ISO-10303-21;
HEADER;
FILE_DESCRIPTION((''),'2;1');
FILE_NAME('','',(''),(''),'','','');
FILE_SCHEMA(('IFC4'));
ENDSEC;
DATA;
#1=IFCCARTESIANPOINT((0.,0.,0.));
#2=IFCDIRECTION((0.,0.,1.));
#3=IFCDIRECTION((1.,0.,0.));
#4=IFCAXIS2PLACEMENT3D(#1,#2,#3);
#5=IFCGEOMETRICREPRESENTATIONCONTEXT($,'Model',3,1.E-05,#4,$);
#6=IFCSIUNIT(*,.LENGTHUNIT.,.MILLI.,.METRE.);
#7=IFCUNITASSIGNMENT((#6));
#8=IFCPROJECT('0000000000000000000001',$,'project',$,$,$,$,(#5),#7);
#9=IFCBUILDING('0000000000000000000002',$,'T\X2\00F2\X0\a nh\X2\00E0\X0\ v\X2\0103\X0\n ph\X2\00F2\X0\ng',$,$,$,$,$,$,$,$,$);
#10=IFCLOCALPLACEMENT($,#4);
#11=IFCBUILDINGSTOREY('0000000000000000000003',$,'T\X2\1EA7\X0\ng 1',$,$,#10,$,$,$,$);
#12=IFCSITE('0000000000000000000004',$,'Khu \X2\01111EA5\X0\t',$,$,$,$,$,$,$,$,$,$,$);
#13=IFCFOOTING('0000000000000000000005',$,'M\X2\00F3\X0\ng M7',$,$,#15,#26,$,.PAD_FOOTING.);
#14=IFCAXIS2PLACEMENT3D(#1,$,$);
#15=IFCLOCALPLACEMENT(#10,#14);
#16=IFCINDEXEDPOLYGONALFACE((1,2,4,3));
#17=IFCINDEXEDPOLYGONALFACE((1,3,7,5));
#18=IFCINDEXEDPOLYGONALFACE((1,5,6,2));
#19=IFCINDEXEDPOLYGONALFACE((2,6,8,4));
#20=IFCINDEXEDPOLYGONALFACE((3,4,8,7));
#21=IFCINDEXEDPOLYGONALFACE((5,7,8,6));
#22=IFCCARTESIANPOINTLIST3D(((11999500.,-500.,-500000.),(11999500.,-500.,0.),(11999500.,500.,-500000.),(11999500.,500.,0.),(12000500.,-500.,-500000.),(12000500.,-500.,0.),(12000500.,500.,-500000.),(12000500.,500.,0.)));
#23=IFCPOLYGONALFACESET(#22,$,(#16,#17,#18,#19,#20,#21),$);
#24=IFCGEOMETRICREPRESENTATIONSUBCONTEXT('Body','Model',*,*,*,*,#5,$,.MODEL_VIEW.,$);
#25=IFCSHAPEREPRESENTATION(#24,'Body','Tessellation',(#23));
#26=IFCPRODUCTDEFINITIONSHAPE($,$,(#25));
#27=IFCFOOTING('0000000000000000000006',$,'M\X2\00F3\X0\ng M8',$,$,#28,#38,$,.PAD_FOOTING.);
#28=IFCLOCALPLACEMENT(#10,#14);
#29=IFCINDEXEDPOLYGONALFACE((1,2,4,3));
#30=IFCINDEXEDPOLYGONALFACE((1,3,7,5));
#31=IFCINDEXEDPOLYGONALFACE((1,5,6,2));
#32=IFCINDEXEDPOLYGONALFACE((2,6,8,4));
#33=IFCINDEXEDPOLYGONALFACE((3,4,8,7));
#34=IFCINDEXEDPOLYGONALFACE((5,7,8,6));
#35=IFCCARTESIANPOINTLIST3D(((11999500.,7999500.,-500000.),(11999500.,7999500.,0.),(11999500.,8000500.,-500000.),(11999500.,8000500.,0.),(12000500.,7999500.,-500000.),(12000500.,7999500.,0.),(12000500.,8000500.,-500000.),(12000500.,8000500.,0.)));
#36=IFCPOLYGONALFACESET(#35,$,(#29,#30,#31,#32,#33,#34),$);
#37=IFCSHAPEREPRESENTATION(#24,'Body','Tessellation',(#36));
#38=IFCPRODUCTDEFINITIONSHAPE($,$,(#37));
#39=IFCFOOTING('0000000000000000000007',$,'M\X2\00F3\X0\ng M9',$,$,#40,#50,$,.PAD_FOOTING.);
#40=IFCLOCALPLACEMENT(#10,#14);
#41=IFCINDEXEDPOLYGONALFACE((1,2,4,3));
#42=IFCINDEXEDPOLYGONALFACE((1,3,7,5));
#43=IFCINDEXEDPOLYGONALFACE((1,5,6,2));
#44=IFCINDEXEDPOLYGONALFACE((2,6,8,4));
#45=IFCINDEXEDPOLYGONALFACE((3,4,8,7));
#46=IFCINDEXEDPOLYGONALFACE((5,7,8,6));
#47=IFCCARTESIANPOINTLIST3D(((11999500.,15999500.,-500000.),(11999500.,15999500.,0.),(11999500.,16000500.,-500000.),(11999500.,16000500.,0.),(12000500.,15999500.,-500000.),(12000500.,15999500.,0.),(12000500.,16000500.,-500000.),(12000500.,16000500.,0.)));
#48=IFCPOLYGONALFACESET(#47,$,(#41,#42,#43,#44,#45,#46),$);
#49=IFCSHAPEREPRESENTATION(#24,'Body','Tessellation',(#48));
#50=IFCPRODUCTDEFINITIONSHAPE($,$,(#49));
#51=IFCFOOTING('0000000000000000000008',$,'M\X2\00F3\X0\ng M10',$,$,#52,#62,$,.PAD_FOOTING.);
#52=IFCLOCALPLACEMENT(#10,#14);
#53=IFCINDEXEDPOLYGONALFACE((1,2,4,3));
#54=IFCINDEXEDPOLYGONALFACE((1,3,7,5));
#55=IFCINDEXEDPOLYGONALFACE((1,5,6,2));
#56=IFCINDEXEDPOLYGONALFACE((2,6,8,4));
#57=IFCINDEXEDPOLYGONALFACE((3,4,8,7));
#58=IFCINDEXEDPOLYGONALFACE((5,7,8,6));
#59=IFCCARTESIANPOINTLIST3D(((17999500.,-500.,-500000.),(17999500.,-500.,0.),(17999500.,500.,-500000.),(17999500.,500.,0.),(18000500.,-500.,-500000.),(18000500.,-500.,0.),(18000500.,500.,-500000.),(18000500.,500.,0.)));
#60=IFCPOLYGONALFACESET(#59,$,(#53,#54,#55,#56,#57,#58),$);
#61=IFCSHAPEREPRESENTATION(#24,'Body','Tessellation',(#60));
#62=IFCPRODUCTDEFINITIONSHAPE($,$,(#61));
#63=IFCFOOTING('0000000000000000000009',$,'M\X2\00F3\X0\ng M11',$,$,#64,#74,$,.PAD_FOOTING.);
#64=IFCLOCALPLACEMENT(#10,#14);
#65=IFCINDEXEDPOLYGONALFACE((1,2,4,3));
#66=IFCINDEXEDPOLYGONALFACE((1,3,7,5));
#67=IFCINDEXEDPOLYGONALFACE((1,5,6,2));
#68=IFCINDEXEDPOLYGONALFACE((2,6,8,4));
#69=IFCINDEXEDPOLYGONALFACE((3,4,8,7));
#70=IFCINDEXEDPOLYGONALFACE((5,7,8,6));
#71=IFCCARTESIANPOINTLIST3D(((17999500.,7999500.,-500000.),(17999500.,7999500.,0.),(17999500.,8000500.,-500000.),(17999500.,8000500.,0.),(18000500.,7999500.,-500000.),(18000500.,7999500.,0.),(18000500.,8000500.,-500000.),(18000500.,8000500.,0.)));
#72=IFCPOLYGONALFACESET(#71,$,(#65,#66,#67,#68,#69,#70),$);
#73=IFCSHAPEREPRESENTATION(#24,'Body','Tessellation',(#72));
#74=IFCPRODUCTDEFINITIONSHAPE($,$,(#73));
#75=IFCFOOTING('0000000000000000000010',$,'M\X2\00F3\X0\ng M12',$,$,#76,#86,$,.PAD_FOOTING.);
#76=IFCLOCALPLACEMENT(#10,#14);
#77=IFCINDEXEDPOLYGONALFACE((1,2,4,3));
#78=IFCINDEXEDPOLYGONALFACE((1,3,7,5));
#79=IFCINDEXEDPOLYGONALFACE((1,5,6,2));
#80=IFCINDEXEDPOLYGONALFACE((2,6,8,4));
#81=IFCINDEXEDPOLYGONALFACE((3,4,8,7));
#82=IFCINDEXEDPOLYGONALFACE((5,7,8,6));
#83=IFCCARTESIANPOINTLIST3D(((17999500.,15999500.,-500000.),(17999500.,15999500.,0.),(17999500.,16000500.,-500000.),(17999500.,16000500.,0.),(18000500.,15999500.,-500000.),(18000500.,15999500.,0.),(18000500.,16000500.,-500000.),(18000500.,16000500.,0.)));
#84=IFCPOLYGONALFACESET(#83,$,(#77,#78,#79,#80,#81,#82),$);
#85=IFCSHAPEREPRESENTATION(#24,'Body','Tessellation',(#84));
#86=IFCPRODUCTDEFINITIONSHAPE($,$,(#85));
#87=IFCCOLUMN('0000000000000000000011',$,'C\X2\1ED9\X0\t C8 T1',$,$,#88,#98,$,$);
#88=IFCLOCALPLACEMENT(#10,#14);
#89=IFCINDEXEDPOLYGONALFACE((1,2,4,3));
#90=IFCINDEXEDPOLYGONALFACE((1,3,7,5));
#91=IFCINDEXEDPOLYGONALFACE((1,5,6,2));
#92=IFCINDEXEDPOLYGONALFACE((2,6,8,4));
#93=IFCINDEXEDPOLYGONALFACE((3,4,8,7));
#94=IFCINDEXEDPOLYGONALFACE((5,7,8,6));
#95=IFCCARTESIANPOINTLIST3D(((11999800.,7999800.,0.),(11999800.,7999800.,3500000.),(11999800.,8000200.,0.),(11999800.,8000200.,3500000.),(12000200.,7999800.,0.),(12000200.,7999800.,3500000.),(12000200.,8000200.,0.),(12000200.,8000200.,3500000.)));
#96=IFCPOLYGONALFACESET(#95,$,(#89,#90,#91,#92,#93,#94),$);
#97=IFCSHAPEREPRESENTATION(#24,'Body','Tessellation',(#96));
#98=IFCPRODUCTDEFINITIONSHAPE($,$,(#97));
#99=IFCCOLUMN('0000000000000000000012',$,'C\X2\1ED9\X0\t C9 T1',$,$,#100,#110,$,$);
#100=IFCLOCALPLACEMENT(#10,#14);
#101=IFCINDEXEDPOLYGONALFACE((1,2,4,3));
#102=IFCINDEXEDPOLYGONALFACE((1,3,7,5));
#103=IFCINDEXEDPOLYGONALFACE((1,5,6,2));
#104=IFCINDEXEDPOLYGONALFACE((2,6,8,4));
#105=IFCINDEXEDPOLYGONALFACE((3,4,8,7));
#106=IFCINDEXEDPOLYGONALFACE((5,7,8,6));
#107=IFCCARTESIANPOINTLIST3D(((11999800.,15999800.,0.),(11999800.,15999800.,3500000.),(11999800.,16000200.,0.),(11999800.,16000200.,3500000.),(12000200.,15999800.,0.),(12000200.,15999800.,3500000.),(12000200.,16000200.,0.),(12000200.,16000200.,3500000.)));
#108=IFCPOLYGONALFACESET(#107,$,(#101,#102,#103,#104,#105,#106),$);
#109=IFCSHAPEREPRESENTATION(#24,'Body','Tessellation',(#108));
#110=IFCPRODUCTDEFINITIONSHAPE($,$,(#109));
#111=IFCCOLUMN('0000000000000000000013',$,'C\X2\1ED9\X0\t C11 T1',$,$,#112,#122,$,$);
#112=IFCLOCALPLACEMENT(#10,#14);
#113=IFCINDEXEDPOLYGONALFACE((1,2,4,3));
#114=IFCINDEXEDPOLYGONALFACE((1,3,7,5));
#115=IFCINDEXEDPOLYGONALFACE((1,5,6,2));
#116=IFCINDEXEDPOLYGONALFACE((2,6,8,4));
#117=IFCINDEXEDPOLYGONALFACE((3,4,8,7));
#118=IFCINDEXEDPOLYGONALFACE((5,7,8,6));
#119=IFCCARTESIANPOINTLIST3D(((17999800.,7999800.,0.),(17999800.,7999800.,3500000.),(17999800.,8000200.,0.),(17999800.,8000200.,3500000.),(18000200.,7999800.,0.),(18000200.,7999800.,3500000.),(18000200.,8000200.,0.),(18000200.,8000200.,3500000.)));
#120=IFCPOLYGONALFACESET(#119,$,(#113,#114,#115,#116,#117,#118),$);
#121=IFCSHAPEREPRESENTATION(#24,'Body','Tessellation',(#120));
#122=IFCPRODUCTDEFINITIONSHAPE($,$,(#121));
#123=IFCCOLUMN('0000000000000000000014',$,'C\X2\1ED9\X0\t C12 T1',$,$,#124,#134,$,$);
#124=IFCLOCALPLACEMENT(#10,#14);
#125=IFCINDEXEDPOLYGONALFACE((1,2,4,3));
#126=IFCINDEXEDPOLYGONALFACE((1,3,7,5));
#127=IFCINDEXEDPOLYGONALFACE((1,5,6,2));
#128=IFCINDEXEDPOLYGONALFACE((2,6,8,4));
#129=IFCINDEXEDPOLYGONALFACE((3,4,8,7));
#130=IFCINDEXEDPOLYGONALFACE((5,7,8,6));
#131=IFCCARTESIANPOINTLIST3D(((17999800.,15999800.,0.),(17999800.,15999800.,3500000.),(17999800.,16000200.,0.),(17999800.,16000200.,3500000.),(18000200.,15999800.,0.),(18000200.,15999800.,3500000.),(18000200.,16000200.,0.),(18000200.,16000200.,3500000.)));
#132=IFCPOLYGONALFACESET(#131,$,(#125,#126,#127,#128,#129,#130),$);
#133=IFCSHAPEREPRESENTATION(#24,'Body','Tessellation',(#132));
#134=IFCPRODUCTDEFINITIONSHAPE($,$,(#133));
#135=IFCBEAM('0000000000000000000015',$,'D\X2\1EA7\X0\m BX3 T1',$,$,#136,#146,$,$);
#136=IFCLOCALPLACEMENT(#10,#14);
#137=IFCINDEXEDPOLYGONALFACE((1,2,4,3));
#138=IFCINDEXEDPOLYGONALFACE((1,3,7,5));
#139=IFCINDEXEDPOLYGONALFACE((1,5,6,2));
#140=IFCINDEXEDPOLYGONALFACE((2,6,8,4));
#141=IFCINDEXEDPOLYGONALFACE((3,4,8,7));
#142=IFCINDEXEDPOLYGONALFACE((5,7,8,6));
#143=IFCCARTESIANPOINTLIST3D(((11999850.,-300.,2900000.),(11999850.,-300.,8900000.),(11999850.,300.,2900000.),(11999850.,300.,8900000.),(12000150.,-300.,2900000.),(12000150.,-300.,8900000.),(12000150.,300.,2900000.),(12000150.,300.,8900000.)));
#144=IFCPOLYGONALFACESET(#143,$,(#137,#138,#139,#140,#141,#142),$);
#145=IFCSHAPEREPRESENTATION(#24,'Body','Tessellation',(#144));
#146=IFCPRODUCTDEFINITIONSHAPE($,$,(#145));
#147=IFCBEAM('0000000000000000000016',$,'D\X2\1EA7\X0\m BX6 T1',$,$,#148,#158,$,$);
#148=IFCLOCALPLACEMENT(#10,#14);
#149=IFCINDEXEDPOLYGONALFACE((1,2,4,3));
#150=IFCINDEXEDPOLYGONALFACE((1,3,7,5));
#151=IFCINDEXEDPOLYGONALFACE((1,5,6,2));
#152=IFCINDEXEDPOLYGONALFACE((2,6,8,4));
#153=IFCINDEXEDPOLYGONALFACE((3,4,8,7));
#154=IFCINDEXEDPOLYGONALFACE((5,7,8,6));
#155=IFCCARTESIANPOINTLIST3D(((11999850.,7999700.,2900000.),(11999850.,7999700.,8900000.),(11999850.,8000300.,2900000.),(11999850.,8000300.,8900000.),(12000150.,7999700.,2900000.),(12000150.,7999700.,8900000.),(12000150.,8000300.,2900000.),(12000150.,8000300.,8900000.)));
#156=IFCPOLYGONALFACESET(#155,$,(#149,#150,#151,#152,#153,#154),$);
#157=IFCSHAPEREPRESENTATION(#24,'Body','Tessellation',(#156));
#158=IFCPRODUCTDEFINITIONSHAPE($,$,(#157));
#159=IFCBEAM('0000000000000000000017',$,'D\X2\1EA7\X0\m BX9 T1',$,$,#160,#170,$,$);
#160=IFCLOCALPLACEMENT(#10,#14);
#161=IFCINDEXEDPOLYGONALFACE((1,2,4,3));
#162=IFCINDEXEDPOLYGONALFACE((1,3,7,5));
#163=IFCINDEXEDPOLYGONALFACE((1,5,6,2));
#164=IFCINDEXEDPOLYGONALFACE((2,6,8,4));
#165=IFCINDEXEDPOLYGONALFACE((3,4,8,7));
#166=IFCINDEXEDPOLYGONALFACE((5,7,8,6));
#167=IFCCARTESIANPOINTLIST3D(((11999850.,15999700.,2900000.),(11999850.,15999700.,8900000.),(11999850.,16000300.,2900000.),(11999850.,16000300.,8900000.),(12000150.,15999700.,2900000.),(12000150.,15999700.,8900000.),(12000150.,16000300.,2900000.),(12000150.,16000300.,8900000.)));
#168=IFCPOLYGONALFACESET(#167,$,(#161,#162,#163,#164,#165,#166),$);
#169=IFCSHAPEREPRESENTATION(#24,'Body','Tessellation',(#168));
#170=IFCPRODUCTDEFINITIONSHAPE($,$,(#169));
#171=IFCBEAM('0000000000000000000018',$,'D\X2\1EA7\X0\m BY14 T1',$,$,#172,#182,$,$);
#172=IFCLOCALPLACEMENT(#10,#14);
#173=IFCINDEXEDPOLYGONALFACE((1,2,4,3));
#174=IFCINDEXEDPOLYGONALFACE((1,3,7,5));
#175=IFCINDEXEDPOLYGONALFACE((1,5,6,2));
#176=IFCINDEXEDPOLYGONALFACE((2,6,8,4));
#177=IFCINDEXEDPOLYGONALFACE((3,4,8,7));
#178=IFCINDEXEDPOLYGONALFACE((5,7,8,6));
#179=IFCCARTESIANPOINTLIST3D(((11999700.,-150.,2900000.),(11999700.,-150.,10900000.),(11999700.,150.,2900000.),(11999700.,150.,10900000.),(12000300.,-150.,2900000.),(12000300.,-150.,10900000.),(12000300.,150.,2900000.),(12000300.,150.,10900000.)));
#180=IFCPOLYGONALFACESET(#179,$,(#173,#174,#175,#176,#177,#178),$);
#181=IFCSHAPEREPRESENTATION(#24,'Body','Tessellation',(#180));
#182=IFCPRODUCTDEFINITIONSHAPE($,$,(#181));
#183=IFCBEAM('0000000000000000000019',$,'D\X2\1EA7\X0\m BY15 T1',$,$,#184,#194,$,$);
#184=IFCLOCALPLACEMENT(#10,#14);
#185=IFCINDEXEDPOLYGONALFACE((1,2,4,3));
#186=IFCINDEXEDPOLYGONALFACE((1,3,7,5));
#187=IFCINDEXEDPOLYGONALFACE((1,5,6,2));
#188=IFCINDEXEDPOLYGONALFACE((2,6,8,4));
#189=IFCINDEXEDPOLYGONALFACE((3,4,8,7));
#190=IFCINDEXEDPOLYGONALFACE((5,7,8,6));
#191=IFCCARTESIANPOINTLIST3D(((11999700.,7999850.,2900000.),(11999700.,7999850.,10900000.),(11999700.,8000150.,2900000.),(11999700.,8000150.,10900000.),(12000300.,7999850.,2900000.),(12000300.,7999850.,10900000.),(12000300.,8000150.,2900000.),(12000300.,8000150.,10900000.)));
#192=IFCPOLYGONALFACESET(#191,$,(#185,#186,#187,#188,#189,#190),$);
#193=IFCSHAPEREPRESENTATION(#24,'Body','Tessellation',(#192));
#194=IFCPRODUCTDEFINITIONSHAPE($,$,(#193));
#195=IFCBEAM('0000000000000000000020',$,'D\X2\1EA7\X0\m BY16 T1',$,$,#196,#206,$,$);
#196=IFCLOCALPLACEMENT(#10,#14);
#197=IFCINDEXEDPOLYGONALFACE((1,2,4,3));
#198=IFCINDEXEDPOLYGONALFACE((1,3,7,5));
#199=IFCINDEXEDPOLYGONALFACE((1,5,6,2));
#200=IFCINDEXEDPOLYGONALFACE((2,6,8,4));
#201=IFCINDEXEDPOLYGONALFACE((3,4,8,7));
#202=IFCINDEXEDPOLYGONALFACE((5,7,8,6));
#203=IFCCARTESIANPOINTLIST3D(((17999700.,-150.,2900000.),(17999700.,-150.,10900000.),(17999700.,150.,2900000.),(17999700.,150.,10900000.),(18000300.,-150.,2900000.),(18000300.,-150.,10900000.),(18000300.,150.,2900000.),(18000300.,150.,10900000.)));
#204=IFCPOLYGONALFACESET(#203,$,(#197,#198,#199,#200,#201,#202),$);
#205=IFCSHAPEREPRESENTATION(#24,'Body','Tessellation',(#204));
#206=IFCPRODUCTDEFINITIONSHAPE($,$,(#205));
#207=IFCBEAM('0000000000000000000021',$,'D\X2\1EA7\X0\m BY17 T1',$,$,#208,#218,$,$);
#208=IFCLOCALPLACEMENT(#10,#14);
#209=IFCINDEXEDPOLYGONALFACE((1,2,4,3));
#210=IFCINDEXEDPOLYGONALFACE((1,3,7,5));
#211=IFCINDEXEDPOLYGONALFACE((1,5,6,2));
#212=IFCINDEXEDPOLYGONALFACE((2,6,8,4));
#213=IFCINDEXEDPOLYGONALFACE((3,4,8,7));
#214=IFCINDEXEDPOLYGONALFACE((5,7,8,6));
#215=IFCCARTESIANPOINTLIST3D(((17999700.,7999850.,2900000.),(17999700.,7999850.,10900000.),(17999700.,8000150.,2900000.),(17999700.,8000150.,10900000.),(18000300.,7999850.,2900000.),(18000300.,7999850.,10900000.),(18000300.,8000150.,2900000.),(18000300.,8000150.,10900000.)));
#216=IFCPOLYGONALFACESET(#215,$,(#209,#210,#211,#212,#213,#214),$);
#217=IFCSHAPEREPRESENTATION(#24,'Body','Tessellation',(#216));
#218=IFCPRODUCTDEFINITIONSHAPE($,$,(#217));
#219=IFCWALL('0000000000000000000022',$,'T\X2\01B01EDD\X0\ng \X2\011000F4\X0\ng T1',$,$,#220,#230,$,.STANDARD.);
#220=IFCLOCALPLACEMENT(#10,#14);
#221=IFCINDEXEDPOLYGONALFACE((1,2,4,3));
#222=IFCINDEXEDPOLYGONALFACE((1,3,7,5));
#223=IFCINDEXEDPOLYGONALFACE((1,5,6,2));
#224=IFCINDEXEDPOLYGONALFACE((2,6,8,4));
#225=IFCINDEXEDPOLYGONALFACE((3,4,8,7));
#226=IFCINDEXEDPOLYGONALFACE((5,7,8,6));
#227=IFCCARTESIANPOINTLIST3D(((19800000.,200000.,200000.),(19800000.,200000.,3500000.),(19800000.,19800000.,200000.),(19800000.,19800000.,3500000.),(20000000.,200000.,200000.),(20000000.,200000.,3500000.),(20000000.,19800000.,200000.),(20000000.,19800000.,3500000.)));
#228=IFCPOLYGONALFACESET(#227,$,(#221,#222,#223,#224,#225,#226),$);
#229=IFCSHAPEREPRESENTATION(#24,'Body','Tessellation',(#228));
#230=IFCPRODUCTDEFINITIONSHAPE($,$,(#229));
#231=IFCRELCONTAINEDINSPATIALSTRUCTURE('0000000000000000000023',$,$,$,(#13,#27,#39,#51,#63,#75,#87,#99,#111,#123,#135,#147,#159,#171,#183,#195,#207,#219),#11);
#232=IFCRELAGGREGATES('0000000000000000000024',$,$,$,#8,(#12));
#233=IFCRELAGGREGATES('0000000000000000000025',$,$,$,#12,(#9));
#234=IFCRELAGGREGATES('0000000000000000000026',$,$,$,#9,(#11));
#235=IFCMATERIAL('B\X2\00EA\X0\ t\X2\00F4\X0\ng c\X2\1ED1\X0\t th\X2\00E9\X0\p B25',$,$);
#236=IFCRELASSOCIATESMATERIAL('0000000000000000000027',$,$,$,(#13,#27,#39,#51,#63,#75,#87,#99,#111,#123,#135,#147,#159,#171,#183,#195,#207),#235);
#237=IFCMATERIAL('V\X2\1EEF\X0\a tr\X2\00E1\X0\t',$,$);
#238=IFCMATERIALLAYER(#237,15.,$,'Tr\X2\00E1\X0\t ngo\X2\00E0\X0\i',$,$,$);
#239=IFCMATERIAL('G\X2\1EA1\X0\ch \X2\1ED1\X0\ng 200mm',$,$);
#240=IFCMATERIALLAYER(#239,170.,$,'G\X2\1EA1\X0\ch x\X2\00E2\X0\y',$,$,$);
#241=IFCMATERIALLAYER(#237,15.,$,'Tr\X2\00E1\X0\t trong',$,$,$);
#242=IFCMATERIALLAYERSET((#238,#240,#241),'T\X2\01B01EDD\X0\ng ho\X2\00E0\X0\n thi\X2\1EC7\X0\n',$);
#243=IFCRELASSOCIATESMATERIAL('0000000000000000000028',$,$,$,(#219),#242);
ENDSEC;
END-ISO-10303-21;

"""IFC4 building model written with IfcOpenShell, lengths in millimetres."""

from ifc_helpers import new_model, entity, si_unit, frame, origin_with_axes, place, context, subcontext, project, spatial, indexed_curve, outline, extrude, material, layer, layer_set, layer_usage, element, save


model = new_model("IFC4")

# Units and contexts
model_context = context("Model", 3, precision=1e-05, world=origin_with_axes())
body_context = subcontext(model_context, "Body", "Model", "MODEL_VIEW")
ifc_project = project(units=[si_unit("LENGTHUNIT", "METRE", prefix="MILLI")], contexts=[model_context])

# Site, building, storey
site = spatial("IfcSite", under=ifc_project, Name="Khu đất")
building = spatial("IfcBuilding", under=site, Name="Tòa nhà văn phòng")
storey_placement = place(None, origin_with_axes())
storey = spatial("IfcBuildingStorey", under=building, at=storey_placement, Name="Tầng 1")

# Footings
ifc_material_1 = material(Name="Bê tông cốt thép B25")
for number, where, z_axis, x_axis, name in (
    (1, (12000000.0, 0.0, -500000.0), (0.0, 0.0, 1.0), (1.0, 0.0, 0.0), "Móng M7"),
    (2, (12000000.0, 8000000.0, -500000.0), (0.0, 0.0, 1.0), (1.0, 0.0, 0.0), "Móng M8"),
    (3, (12000000.0, 16000000.0, -500000.0), (0.0, 0.0, 1.0), (1.0, 0.0, 0.0), "Móng M9"),
    (4, (18000000.0, 0.0, -500000.0), (0.0, 0.0, 1.0), (1.0, 0.0, 0.0), "Móng M10"),
    (5, (18000000.0, 8000000.0, -500000.0), (0.0, 0.0, 1.0), (1.0, 0.0, 0.0), "Móng M11"),
    (6, (18000000.0, 16000000.0, -500000.0), (0.0, 0.0, 1.0), (1.0, 0.0, 0.0), "Móng M12"),
):
    element("IfcFooting", number, at=place(storey_placement, frame(where, z_axis=z_axis, x_axis=x_axis)), inside=storey, material=ifc_material_1, Name=name, PredefinedType="PAD_FOOTING", context=body_context, shape_type="SweptSolid", body=[
        extrude(entity("IfcRectangleProfileDef", None, None, None, 1000.0, 1000.0), origin_with_axes(), (0.0, 0.0, 1.0), 500000.0),
    ])

# Columns
for number, where, z_axis, x_axis, name in (
    (7, (12000000.0, 8000000.0, 0.0), (0.0, 0.0, 1.0), (1.0, 0.0, 0.0), "Cột C8 T1"),
    (8, (12000000.0, 16000000.0, 0.0), (0.0, 0.0, 1.0), (1.0, 0.0, 0.0), "Cột C9 T1"),
    (9, (18000000.0, 8000000.0, 0.0), (0.0, 0.0, 1.0), (1.0, 0.0, 0.0), "Cột C11 T1"),
    (10, (18000000.0, 16000000.0, 0.0), (0.0, 0.0, 1.0), (1.0, 0.0, 0.0), "Cột C12 T1"),
):
    element("IfcColumn", number, at=place(storey_placement, frame(where, z_axis=z_axis, x_axis=x_axis)), inside=storey, material=ifc_material_1, Name=name, context=body_context, shape_type="SweptSolid", body=[
        extrude(entity("IfcRectangleProfileDef", None, None, None, 400.0, 400.0), origin_with_axes(), (0.0, 0.0, 1.0), 3500000.0),
    ])

# Beams
for number, where, z_axis, x_axis, name in (
    (11, (12000000.0, 0.0, 2900000.0), (0.0, 0.0, 1.0), (1.0, 0.0, 0.0), "Dầm BX3 T1"),
    (12, (12000000.0, 8000000.0, 2900000.0), (0.0, 0.0, 1.0), (1.0, 0.0, 0.0), "Dầm BX6 T1"),
    (13, (12000000.0, 16000000.0, 2900000.0), (0.0, 0.0, 1.0), (1.0, 0.0, 0.0), "Dầm BX9 T1"),
):
    element("IfcBeam", number, at=place(storey_placement, frame(where, z_axis=z_axis, x_axis=x_axis)), inside=storey, material=ifc_material_1, Name=name, context=body_context, shape_type="SweptSolid", body=[
        extrude(entity("IfcRectangleProfileDef", None, None, None, 300.0, 600.0), origin_with_axes(), (0.0, 0.0, 1.0), 6000000.0),
    ])
for number, where, z_axis, x_axis, name in (
    (14, (12000000.0, 0.0, 2900000.0), (0.0, 0.0, 1.0), (0.0, 1.0, 0.0), "Dầm BY14 T1"),
    (15, (12000000.0, 8000000.0, 2900000.0), (0.0, 0.0, 1.0), (0.0, 1.0, 0.0), "Dầm BY15 T1"),
    (16, (18000000.0, 0.0, 2900000.0), (0.0, 0.0, 1.0), (0.0, 1.0, 0.0), "Dầm BY16 T1"),
    (17, (18000000.0, 8000000.0, 2900000.0), (0.0, 0.0, 1.0), (0.0, 1.0, 0.0), "Dầm BY17 T1"),
):
    element("IfcBeam", number, at=place(storey_placement, frame(where, z_axis=z_axis, x_axis=x_axis)), inside=storey, material=ifc_material_1, Name=name, context=body_context, shape_type="SweptSolid", body=[
        extrude(entity("IfcRectangleProfileDef", None, None, None, 300.0, 600.0), origin_with_axes(), (0.0, 0.0, 1.0), 8000000.0),
    ])

# Wall
ifc_material_2 = material(Name="Vữa trát")
ifc_layer_1 = layer(ifc_material_2, 15.0, Name="Trát ngoài")
ifc_material_3 = material(Name="Gạch ống 200mm")
ifc_layer_2 = layer(ifc_material_3, 170.0, Name="Gạch xây")
ifc_layer_3 = layer(ifc_material_2, 15.0, Name="Trát trong")
ifc_layer_set = layer_set([ifc_layer_1, ifc_layer_2, ifc_layer_3], Name="Tường hoàn thiện")
ifc_layer_usage = layer_usage(ifc_layer_set, "AXIS2", "POSITIVE", 0.0)
wall_placement = place(storey_placement, frame((19800000.0, 200000.0, 200000.0), z_axis=(0.0, 0.0, 1.0), x_axis=(1.0, 0.0, 0.0)))
element("IfcWall", 18, at=wall_placement, inside=storey, material=ifc_layer_usage, Name="Tường Đông T1", PredefinedType="STANDARD", context=body_context, shape_type="SweptSolid", body=[
    extrude(outline(indexed_curve([(0.0, 0.0), (0.0, 19600000.0), (200000.0, 19600000.0), (200000.0, 0.0), (0.0, 0.0)], self_intersect=False)), origin_with_axes(), (0.0, 0.0, 1.0), 3300000.0),
])

save(model, "model.ifc")
